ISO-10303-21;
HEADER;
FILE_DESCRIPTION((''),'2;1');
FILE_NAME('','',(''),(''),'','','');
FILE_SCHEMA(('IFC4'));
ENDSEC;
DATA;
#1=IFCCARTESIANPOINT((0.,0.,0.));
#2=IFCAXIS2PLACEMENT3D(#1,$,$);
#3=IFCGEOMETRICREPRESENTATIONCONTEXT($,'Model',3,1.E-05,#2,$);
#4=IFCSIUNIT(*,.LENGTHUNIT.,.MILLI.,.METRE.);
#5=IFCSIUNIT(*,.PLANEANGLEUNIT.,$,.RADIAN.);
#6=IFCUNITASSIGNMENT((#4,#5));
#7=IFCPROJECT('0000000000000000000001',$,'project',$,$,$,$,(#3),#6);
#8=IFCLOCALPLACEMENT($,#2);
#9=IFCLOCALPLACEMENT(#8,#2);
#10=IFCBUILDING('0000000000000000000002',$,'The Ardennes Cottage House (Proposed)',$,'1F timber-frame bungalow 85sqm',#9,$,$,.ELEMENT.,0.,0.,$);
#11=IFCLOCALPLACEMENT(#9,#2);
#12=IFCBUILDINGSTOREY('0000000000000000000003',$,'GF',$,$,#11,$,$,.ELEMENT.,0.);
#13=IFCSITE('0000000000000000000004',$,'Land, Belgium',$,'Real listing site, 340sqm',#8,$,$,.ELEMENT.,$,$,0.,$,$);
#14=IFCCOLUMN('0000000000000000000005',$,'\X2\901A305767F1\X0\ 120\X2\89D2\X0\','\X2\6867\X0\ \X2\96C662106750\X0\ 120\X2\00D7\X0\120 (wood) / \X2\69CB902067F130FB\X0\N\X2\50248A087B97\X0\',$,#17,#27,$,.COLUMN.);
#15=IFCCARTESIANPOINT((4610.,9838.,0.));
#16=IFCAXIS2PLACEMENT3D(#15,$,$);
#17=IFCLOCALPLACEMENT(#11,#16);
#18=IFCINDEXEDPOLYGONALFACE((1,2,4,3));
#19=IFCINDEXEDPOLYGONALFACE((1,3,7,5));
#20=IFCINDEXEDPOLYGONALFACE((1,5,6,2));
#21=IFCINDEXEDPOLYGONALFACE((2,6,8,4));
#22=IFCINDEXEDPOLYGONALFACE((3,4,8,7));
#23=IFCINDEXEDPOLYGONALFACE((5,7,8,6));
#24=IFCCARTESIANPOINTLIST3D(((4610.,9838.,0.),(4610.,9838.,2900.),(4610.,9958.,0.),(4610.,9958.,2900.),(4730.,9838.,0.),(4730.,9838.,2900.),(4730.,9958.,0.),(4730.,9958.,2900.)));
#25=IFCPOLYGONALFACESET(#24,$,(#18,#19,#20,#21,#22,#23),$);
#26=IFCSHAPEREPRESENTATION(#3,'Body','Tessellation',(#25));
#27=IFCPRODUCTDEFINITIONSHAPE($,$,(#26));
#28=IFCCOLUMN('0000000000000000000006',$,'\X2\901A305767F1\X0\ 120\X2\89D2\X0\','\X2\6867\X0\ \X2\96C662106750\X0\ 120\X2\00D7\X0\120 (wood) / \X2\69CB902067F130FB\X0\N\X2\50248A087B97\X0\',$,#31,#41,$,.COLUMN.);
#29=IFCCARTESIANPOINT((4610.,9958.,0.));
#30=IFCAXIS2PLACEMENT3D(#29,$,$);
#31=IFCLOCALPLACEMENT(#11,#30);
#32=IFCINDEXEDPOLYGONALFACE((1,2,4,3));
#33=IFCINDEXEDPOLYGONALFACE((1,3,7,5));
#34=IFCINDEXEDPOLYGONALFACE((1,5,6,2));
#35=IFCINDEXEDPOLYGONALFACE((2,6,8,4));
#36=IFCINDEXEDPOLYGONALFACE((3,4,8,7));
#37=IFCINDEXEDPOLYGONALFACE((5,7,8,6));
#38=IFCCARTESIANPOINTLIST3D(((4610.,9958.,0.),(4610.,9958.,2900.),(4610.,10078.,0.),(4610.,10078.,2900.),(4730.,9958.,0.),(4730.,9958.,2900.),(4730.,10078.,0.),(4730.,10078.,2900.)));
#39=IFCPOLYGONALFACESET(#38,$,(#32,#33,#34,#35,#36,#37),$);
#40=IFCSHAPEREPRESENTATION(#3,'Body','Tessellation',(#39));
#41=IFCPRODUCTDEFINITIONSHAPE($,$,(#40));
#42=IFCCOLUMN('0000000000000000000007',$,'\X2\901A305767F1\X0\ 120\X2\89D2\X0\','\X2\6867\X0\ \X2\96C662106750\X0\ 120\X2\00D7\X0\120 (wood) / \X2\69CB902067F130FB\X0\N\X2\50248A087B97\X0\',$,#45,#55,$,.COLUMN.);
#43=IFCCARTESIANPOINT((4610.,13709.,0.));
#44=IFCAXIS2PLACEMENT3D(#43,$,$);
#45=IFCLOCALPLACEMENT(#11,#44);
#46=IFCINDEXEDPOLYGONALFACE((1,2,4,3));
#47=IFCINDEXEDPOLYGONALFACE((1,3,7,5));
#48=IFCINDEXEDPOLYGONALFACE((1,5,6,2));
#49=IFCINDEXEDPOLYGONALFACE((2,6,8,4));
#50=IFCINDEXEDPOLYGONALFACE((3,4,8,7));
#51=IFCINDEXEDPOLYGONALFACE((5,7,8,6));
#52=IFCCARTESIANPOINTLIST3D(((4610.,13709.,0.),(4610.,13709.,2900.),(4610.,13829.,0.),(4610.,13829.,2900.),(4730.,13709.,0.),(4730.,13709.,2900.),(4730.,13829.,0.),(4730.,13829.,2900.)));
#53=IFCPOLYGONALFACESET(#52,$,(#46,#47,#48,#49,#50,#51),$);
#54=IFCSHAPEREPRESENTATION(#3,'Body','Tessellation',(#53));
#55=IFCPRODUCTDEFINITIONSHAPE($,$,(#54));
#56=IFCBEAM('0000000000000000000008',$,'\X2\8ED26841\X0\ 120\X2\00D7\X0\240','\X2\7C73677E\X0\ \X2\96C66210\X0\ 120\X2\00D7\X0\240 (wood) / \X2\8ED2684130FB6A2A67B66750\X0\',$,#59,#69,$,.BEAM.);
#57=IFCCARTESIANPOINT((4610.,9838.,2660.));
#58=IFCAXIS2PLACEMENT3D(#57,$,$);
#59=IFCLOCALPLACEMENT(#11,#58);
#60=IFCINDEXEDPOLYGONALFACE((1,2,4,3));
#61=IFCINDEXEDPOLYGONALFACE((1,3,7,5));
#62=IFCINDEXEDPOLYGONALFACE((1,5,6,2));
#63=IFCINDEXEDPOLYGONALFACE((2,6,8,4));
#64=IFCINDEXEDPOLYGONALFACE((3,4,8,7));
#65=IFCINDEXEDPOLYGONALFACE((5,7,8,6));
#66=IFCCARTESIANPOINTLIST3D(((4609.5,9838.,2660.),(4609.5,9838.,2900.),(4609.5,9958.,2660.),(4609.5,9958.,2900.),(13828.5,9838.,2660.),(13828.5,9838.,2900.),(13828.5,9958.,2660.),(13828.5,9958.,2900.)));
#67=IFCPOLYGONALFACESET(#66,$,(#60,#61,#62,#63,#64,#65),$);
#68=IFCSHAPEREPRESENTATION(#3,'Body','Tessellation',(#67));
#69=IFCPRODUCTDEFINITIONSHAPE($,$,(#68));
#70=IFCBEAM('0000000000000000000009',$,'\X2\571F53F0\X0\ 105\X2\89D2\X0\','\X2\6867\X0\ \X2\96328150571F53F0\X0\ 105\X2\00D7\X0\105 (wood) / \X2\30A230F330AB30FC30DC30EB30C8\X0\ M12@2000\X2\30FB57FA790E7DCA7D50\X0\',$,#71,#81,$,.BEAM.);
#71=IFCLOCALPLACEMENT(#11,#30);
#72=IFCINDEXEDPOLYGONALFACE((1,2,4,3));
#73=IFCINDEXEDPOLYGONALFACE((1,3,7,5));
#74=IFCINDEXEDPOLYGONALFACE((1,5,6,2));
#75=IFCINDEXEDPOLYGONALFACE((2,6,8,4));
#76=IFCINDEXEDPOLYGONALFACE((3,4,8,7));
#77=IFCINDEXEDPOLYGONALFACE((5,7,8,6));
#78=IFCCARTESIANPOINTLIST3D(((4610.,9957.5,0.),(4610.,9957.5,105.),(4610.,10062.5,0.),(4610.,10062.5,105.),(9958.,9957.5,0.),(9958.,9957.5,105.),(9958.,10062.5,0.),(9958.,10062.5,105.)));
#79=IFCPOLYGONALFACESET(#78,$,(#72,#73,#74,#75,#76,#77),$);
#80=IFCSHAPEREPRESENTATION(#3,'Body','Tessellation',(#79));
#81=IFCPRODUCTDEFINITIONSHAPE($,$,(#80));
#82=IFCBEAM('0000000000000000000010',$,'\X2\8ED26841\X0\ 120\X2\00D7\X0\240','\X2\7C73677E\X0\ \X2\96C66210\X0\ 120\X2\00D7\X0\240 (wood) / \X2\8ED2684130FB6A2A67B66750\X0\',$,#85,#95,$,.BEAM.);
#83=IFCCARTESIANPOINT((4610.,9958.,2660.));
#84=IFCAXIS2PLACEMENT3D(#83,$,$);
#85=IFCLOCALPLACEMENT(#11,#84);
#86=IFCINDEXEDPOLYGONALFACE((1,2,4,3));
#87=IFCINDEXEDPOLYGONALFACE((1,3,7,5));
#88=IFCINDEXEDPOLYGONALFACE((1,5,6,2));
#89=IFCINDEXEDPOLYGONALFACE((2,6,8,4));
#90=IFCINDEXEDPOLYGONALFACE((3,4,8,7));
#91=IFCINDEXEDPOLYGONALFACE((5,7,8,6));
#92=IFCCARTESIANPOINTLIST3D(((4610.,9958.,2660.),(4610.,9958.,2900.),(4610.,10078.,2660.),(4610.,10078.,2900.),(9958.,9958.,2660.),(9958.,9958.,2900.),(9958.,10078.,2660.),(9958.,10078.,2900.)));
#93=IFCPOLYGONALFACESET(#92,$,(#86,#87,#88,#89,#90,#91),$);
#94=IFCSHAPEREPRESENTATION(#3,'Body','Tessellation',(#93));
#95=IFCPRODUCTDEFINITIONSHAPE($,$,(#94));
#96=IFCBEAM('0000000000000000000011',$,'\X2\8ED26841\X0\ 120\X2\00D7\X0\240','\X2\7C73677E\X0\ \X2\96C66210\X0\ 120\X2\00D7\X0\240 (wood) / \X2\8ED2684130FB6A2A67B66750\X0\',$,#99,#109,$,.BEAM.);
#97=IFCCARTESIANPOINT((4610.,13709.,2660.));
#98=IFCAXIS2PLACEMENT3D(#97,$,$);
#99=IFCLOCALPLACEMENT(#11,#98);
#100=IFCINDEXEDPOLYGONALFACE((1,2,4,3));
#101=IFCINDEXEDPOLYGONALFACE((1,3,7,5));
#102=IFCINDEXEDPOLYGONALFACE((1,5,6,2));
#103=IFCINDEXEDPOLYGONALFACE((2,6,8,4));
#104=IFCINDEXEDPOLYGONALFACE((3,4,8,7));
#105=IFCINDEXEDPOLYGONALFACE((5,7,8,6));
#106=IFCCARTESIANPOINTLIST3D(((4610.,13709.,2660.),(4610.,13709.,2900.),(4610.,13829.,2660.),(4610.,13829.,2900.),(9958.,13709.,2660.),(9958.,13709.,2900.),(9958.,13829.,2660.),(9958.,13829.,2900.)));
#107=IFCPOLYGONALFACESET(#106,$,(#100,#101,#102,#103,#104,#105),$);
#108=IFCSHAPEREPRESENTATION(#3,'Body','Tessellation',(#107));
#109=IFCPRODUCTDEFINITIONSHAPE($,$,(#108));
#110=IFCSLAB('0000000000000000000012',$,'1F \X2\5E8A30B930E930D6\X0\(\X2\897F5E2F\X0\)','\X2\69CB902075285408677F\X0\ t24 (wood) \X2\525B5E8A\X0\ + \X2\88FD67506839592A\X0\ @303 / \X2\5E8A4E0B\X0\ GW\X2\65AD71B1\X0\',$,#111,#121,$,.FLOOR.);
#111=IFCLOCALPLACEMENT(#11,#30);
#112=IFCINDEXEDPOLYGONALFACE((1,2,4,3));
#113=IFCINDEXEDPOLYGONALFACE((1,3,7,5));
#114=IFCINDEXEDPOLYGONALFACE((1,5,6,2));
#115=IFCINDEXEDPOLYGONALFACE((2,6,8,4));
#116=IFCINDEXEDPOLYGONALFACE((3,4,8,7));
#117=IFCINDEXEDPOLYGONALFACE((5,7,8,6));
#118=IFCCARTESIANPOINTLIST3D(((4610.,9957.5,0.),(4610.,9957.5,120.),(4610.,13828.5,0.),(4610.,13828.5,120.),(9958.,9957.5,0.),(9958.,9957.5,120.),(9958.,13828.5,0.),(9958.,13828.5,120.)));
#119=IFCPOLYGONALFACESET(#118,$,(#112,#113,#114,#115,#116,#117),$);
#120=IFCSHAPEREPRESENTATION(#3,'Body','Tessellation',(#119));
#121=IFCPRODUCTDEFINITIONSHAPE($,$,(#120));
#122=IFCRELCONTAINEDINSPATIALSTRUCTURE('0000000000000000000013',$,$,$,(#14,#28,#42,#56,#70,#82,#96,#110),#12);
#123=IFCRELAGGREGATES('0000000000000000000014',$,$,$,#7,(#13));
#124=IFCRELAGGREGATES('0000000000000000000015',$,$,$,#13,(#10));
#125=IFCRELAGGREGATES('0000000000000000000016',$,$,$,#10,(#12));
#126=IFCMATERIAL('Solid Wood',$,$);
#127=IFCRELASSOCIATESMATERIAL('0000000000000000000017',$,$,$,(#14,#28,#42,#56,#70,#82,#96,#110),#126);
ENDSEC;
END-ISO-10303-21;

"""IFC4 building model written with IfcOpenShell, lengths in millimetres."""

from ifc_helpers import new_model, si_unit, frame, frame_2d, origin, place, context, project, spatial, rectangle, extrude, material, element, save


model = new_model("IFC4")

# Units and contexts
model_context = context("Model", 3, precision=1e-05, world=origin())
ifc_project = project(units=[si_unit("LENGTHUNIT", "METRE", prefix="MILLI"), si_unit("PLANEANGLEUNIT", "RADIAN")], contexts=[model_context])

# Site, building, storey
site_placement = place(None, origin())
site = spatial("IfcSite", under=ifc_project, at=site_placement, Name="Land, Belgium", ObjectType="Real listing site, 340sqm", CompositionType="ELEMENT", RefElevation=0.0)
building_placement = place(site_placement, origin())
building = spatial("IfcBuilding", under=site, at=building_placement, Name="The Ardennes Cottage House (Proposed)", ObjectType="1F timber-frame bungalow 85sqm", CompositionType="ELEMENT", ElevationOfRefHeight=0.0, ElevationOfTerrain=0.0)
storey_placement = place(building_placement, origin())
storey = spatial("IfcBuildingStorey", under=building, at=storey_placement, Name="GF", CompositionType="ELEMENT", Elevation=0.0)

# Columns
ifc_material_1 = material(Name="Solid Wood")
column_1_placement = place(storey_placement, frame((4610.0, 9838.0, 0.0)))
element("IfcColumn", 1, at=column_1_placement, inside=storey, material=ifc_material_1, Name="通し柱 120角", Description="桧 集成材 120×120 (wood) / 構造柱・N値計算", PredefinedType="COLUMN", context=model_context, shape_type="SweptSolid", body=[
    extrude(rectangle(XDim=120.0, YDim=120.0, at=frame_2d((60.0, 60.0))), frame((4610.0, 9838.0, 0.0)), (0.0, 0.0, 1.0), 2900.0),
])
column_2_placement = place(storey_placement, frame((4610.0, 9958.0, 0.0)))
element("IfcColumn", 2, at=column_2_placement, inside=storey, material=ifc_material_1, Name="通し柱 120角", Description="桧 集成材 120×120 (wood) / 構造柱・N値計算", PredefinedType="COLUMN", context=model_context, shape_type="SweptSolid", body=[
    extrude(rectangle(XDim=120.0, YDim=120.0, at=frame_2d((60.0, 60.0))), frame((4610.0, 9958.0, 0.0)), (0.0, 0.0, 1.0), 2900.0),
])
column_3_placement = place(storey_placement, frame((4610.0, 13709.0, 0.0)))
element("IfcColumn", 3, at=column_3_placement, inside=storey, material=ifc_material_1, Name="通し柱 120角", Description="桧 集成材 120×120 (wood) / 構造柱・N値計算", PredefinedType="COLUMN", context=model_context, shape_type="SweptSolid", body=[
    extrude(rectangle(XDim=120.0, YDim=120.0, at=frame_2d((60.0, 60.0))), frame((4610.0, 13709.0, 0.0)), (0.0, 0.0, 1.0), 2900.0),
])

# Beams
beam_1_placement = place(storey_placement, frame((4610.0, 9838.0, 2660.0)))
element("IfcBeam", 4, at=beam_1_placement, inside=storey, material=ifc_material_1, Name="軒桁 120×240", Description="米松 集成 120×240 (wood) / 軒桁・横架材", PredefinedType="BEAM", context=model_context, shape_type="SweptSolid", body=[
    extrude(rectangle(XDim=9219.0, YDim=120.0, at=frame_2d((4609.0, 60.0))), frame((4610.0, 9838.0, 2660.0)), (0.0, 0.0, 1.0), 240.0),
])
beam_2_placement = place(storey_placement, frame((4610.0, 9958.0, 0.0)))
element("IfcBeam", 5, at=beam_2_placement, inside=storey, material=ifc_material_1, Name="土台 105角", Description="桧 防腐土台 105×105 (wood) / アンカーボルト M12@2000・基礎緊結", PredefinedType="BEAM", context=model_context, shape_type="SweptSolid", body=[
    extrude(rectangle(XDim=5348.0, YDim=105.0, at=frame_2d((2674.0, 52.0))), frame((4610.0, 9958.0, 0.0)), (0.0, 0.0, 1.0), 105.0),
])
beam_3_placement = place(storey_placement, frame((4610.0, 9958.0, 2660.0)))
element("IfcBeam", 6, at=beam_3_placement, inside=storey, material=ifc_material_1, Name="軒桁 120×240", Description="米松 集成 120×240 (wood) / 軒桁・横架材", PredefinedType="BEAM", context=model_context, shape_type="SweptSolid", body=[
    extrude(rectangle(XDim=5348.0, YDim=120.0, at=frame_2d((2674.0, 60.0))), frame((4610.0, 9958.0, 2660.0)), (0.0, 0.0, 1.0), 240.0),
])
beam_4_placement = place(storey_placement, frame((4610.0, 13709.0, 2660.0)))
element("IfcBeam", 7, at=beam_4_placement, inside=storey, material=ifc_material_1, Name="軒桁 120×240", Description="米松 集成 120×240 (wood) / 軒桁・横架材", PredefinedType="BEAM", context=model_context, shape_type="SweptSolid", body=[
    extrude(rectangle(XDim=5348.0, YDim=120.0, at=frame_2d((2674.0, 60.0))), frame((4610.0, 13709.0, 2660.0)), (0.0, 0.0, 1.0), 240.0),
])

# Slab
slab_placement = place(storey_placement, frame((4610.0, 9958.0, 0.0)))
element("IfcSlab", 8, at=slab_placement, inside=storey, material=ifc_material_1, Name="1F 床スラブ(西帯)", Description="構造用合板 t24 (wood) 剛床 + 製材根太 @303 / 床下 GW断熱", PredefinedType="FLOOR", context=model_context, shape_type="SweptSolid", body=[
    extrude(rectangle(XDim=5348.0, YDim=3871.0, at=frame_2d((2674.0, 1935.0))), frame((4610.0, 9958.0, 0.0)), (0.0, 0.0, 1.0), 120.0),
])

save(model, "model.ifc")
